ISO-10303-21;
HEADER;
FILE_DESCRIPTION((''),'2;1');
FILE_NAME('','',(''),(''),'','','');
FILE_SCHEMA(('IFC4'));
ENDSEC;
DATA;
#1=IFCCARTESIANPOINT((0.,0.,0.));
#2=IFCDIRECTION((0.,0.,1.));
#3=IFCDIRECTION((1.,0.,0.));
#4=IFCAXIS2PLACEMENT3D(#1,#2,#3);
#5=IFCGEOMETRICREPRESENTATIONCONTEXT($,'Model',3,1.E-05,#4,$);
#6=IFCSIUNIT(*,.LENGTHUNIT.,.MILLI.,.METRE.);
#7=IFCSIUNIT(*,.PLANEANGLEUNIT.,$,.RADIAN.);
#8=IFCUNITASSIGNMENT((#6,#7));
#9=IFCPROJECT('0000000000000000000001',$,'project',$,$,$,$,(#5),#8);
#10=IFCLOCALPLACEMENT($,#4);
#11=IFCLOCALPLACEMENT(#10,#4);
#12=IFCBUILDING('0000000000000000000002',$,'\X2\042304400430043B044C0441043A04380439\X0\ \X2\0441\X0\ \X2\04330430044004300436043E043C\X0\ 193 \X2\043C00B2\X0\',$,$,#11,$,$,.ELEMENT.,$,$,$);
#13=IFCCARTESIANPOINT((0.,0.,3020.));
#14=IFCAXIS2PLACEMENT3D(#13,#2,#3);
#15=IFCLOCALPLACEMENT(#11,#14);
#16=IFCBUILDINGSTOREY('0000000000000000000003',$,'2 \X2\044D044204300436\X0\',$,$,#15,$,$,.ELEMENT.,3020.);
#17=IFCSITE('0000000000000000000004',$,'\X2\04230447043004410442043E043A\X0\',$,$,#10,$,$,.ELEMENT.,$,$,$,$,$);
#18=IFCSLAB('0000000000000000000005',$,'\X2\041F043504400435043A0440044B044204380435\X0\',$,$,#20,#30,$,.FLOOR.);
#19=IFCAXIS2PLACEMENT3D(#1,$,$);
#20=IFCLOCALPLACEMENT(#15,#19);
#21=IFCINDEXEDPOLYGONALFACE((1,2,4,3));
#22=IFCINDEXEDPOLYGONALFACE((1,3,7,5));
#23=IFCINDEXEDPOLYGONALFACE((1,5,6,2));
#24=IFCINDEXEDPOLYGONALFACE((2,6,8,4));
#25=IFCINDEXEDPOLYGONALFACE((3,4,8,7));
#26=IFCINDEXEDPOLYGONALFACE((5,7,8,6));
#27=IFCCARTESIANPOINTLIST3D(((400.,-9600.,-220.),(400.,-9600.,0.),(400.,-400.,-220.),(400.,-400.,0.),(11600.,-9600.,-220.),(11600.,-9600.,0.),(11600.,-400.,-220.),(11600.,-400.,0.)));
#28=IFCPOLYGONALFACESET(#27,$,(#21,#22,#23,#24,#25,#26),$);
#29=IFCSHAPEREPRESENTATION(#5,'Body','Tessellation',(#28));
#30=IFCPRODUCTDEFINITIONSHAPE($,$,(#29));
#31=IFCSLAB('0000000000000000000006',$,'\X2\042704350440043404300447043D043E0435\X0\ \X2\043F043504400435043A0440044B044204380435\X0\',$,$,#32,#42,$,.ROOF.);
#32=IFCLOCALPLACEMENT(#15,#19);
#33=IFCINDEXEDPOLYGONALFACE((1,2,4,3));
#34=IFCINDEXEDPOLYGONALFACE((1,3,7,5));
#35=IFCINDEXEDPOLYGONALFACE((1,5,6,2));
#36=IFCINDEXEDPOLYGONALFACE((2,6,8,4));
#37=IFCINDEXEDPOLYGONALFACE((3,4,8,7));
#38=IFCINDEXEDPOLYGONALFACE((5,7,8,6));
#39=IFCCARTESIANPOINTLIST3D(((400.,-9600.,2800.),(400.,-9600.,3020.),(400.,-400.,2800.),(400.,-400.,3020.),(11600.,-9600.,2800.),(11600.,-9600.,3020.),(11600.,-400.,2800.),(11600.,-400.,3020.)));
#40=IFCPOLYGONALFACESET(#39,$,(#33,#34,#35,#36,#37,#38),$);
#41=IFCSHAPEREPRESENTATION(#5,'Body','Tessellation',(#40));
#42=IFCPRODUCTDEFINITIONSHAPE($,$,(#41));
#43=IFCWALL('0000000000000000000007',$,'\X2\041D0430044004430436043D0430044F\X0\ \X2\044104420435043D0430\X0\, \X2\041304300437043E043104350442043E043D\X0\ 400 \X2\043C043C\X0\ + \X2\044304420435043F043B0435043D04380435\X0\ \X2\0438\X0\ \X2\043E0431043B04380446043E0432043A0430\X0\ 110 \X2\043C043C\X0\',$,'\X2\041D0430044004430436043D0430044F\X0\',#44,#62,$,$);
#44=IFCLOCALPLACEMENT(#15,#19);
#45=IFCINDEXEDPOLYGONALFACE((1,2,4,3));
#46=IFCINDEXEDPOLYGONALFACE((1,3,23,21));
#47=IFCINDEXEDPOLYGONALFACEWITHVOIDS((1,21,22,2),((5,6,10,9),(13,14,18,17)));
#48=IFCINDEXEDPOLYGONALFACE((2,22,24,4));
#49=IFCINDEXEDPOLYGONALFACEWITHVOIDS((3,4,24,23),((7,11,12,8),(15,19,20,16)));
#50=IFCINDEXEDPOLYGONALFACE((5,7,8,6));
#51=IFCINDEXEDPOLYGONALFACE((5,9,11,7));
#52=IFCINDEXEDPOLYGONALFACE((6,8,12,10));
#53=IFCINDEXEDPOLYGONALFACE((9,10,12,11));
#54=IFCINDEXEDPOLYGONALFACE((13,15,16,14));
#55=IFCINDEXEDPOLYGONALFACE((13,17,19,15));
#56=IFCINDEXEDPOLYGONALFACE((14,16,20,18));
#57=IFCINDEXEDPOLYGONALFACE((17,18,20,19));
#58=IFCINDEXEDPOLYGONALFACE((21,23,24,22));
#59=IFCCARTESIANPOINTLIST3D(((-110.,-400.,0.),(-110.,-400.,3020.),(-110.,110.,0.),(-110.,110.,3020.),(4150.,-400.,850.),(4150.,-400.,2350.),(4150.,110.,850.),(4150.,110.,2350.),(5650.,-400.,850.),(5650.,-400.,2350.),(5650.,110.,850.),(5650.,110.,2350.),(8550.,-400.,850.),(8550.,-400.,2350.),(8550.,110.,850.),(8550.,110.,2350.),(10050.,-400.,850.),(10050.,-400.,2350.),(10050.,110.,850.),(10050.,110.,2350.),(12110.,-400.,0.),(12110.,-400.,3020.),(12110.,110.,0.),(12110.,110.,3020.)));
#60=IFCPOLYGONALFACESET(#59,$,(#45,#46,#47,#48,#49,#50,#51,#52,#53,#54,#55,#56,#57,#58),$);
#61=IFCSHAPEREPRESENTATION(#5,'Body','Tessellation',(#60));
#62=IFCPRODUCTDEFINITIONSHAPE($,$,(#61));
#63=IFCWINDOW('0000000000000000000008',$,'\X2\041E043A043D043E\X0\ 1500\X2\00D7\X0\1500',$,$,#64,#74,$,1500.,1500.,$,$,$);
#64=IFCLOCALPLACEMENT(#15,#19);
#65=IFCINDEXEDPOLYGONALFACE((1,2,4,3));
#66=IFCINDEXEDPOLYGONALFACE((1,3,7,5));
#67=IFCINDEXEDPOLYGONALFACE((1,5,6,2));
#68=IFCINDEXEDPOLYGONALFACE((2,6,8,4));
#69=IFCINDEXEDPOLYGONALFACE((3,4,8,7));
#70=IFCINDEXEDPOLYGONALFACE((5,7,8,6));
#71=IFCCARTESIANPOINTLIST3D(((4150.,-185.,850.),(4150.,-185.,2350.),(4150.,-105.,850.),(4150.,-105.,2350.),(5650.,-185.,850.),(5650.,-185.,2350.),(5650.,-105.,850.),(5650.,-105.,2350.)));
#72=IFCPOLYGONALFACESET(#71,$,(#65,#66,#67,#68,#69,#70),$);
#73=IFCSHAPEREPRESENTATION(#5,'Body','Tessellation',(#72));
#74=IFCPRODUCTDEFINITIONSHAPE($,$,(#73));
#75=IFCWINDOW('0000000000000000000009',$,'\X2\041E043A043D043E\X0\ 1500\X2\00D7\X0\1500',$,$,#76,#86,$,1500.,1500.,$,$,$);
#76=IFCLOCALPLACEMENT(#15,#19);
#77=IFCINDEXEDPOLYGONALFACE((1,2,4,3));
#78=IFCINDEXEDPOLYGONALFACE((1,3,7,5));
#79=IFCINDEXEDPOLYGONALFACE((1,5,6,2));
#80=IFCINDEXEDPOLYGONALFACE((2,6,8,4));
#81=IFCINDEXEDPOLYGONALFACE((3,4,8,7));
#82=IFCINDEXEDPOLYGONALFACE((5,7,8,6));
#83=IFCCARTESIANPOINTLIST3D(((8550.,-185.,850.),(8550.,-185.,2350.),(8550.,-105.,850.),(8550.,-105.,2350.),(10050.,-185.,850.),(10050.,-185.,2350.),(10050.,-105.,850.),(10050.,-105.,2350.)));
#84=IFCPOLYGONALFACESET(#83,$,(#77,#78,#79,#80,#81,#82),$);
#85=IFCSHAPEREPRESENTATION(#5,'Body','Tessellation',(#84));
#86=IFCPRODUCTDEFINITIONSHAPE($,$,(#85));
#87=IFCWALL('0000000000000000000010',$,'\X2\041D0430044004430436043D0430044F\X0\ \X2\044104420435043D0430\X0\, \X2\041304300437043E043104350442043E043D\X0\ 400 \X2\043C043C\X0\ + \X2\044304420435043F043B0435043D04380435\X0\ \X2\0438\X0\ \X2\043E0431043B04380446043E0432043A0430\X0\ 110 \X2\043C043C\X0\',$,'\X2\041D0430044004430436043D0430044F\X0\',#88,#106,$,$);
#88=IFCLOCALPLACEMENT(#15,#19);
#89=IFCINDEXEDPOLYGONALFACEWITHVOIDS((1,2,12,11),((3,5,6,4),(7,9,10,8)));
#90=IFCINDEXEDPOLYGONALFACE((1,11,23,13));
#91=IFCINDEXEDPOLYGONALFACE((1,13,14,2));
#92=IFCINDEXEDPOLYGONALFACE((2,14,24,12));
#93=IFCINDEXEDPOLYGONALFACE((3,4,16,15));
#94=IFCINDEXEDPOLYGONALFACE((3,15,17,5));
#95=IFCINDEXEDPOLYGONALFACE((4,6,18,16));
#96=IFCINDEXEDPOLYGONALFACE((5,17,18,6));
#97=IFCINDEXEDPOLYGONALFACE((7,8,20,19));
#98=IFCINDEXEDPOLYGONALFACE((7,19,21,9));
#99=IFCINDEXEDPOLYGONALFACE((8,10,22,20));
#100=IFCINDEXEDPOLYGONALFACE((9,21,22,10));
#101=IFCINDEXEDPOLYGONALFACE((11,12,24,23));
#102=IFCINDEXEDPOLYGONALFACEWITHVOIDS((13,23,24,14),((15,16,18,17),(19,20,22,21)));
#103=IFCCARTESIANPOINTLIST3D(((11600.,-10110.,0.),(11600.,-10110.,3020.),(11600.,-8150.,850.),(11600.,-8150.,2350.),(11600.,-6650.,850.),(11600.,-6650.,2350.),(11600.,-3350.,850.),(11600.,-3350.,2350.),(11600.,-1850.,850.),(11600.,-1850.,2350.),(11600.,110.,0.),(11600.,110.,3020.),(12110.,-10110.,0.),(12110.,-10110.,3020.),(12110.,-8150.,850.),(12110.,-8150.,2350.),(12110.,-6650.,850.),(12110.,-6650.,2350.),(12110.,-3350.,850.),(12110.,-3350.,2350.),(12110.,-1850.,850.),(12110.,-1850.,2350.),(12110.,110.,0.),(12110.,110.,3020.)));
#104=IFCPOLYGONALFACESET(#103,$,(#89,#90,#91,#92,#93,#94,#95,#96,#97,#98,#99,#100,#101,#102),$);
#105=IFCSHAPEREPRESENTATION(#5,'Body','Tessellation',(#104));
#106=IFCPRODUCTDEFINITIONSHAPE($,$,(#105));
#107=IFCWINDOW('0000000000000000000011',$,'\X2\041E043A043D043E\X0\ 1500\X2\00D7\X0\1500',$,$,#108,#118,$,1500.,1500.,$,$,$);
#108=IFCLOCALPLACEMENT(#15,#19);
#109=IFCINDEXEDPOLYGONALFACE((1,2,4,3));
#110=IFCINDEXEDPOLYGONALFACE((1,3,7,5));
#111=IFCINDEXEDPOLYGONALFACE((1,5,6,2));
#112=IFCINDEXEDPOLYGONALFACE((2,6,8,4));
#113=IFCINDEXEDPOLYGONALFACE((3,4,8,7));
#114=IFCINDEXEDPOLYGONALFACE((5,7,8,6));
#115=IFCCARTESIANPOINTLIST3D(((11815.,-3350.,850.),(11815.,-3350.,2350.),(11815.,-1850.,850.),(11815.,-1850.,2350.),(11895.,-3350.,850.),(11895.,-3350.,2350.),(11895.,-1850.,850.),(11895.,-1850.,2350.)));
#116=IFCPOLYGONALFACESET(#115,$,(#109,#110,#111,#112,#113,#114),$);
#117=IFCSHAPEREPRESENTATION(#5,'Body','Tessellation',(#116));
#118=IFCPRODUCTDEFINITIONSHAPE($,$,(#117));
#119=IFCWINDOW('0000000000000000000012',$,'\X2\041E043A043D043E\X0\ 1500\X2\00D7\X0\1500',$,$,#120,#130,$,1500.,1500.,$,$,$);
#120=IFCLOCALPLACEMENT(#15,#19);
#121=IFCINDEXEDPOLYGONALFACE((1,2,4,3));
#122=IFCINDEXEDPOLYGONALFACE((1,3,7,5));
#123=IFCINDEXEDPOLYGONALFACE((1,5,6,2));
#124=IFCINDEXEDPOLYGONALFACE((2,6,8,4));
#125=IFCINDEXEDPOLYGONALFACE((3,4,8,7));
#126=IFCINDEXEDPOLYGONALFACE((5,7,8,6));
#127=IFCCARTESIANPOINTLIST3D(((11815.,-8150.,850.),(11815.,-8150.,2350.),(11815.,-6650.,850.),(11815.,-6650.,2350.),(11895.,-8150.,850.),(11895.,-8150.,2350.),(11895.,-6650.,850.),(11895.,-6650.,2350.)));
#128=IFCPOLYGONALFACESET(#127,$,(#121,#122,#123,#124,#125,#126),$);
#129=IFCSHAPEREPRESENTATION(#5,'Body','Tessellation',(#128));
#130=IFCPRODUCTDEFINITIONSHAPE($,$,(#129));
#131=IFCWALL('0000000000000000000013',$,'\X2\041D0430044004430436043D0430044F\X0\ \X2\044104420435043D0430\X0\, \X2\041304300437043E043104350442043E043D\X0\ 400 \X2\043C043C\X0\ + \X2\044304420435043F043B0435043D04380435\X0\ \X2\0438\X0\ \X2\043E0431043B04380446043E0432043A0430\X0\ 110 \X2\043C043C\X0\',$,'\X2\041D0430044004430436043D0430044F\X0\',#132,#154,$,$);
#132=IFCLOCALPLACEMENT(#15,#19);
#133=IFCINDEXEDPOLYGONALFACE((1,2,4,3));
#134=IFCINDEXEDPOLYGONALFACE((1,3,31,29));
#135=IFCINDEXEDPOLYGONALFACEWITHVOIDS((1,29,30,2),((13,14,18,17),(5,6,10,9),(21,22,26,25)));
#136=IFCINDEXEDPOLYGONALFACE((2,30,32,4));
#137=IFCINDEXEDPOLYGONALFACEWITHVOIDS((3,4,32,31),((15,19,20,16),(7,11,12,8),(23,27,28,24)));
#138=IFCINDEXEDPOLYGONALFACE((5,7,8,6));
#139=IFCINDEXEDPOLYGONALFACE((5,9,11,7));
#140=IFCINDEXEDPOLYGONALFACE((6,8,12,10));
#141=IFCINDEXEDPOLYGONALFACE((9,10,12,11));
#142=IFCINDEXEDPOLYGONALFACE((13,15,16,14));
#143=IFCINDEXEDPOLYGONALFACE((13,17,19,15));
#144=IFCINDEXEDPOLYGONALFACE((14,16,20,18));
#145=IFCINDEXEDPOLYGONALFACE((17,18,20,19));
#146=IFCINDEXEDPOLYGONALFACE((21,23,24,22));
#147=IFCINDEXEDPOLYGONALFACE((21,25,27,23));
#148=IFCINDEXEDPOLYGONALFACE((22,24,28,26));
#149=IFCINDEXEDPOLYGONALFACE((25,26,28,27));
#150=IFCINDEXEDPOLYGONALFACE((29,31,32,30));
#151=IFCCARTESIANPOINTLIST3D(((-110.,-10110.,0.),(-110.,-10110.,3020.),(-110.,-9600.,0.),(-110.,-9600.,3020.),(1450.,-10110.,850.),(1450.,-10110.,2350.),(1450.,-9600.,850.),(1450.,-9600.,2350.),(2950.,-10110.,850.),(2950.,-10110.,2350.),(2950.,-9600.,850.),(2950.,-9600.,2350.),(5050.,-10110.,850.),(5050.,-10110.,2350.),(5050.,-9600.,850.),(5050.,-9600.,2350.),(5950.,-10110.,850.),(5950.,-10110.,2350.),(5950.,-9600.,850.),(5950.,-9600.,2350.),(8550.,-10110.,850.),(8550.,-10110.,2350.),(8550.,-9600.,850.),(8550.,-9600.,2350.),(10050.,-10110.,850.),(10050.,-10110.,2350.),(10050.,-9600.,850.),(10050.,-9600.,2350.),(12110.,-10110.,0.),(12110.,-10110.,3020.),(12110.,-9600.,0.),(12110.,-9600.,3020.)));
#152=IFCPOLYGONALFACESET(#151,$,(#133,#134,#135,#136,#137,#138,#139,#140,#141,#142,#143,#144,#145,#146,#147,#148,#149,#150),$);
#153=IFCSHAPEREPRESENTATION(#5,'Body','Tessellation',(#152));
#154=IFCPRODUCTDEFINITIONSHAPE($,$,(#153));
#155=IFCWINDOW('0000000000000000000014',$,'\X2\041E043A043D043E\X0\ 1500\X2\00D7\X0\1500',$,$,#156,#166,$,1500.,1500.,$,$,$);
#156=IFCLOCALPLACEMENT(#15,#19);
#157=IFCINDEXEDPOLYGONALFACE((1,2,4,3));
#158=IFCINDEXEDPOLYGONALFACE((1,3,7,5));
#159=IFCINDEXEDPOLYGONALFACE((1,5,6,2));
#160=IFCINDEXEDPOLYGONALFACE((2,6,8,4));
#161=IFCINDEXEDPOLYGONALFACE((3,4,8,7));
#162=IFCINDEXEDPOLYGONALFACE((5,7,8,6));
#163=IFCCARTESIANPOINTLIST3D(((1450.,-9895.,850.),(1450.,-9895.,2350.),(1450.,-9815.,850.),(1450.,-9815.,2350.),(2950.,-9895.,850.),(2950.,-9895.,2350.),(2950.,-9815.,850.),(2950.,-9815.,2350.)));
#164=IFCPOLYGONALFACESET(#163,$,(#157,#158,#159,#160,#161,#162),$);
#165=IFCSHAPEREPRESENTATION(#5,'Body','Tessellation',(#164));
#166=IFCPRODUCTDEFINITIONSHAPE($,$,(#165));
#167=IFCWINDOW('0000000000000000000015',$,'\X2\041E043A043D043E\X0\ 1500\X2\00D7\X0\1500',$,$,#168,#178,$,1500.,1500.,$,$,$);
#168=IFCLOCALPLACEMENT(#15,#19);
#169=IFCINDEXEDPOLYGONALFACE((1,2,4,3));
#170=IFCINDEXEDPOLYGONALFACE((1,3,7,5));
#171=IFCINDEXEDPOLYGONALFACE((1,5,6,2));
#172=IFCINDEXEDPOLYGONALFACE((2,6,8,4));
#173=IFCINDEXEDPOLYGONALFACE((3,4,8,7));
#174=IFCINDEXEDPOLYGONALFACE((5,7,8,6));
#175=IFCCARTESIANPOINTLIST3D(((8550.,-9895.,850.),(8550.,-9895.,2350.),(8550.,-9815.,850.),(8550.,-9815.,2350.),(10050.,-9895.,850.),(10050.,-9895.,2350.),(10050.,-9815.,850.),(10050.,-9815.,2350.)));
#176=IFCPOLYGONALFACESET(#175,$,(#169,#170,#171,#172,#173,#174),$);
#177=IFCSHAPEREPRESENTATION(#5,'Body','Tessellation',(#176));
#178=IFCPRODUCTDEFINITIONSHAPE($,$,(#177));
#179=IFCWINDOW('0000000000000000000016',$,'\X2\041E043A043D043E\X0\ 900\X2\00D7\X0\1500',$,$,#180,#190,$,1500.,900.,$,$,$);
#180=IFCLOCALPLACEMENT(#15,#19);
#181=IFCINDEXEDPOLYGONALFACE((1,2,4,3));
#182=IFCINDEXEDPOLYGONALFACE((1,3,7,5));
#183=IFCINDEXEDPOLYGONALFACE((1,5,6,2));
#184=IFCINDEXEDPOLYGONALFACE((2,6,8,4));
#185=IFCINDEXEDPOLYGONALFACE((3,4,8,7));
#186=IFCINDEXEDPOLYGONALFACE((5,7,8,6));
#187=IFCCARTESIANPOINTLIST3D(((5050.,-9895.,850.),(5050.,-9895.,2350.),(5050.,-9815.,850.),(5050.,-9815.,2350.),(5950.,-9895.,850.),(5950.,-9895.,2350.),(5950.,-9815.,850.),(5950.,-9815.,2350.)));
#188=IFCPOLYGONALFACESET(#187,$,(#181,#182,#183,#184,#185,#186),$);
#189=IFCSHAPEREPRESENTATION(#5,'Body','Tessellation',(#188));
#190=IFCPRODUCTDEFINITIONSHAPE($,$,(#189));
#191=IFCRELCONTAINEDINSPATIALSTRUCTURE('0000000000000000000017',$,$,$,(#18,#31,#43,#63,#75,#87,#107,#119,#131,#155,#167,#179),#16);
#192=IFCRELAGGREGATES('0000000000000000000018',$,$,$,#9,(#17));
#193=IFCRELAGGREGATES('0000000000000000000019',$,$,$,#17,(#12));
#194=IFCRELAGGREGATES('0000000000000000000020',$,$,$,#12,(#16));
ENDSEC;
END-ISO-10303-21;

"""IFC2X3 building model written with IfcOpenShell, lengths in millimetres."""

from ifc_helpers import new_model, si_unit, frame, frame_2d, origin, origin_with_axes, place, context, project, spatial, polyline, rectangle, outline, extrude, element, fill, save


model = new_model("IFC2X3")

# Units and contexts
model_context = context("Model", 3, precision=1e-05, world=origin_with_axes())
ifc_project = project(units=[si_unit("LENGTHUNIT", "METRE", prefix="MILLI"), si_unit("PLANEANGLEUNIT", "RADIAN")], contexts=[model_context])

# Site, building, storey
site_placement = place(None, origin_with_axes())
site = spatial("IfcSite", under=ifc_project, at=site_placement, Name="Участок", CompositionType="ELEMENT")
building_placement = place(site_placement, origin_with_axes())
building = spatial("IfcBuilding", under=site, at=building_placement, Name="Уральский с гаражом 193 м²", CompositionType="ELEMENT")
storey_placement = place(building_placement, frame((0.0, 0.0, 3020.0), z_axis=(0.0, 0.0, 1.0), x_axis=(1.0, 0.0, 0.0)))
storey = spatial("IfcBuildingStorey", under=building, at=storey_placement, Name="2 этаж", CompositionType="ELEMENT", Elevation=3020.0)

# Slabs
slab_1_placement = place(storey_placement, origin_with_axes())
element("IfcSlab", 1, at=slab_1_placement, inside=storey, Name="Перекрытие", PredefinedType="FLOOR", context=model_context, shape_type="SweptSolid", body=[
    extrude(outline(polyline([(400.0, -400.0), (11600.0, -400.0), (11600.0, -9600.0), (400.0, -9600.0), (400.0, -400.0)])), frame((0.0, 0.0, -220.0)), (0.0, 0.0, 1.0), 220.0),
])
slab_2_placement = place(storey_placement, origin_with_axes())
element("IfcSlab", 2, at=slab_2_placement, inside=storey, Name="Чердачное перекрытие", PredefinedType="ROOF", context=model_context, shape_type="SweptSolid", body=[
    extrude(outline(polyline([(400.0, -400.0), (11600.0, -400.0), (11600.0, -9600.0), (400.0, -9600.0), (400.0, -400.0)])), frame((0.0, 0.0, 2800.0)), (0.0, 0.0, 1.0), 220.0),
])

# Walls, openings, windows
wall_1_placement = place(storey_placement, origin_with_axes())
wall_1 = element("IfcWall", 3, at=wall_1_placement, inside=storey, Name="Наружная стена, Газобетон 400 мм + утепление и облицовка 110 мм", ObjectType="Наружная", context=model_context, shape_type="SweptSolid", body=[
    extrude(rectangle(XDim=12220.0, YDim=510.0, at=frame_2d((6000.0, -145.0))), origin(), (0.0, 0.0, 1.0), 3020.0),
])
opening_1_placement = place(storey_placement, origin_with_axes())
opening_1 = element("IfcOpeningElement", 4, at=opening_1_placement, cuts=wall_1, ObjectType="Opening", context=model_context, shape_type="SweptSolid", body=[
    extrude(rectangle(XDim=1500.0, YDim=530.0, at=frame_2d((4900.0, -145.0))), frame((0.0, 0.0, 850.0)), (0.0, 0.0, 1.0), 1500.0),
])
opening_2_placement = place(storey_placement, origin_with_axes())
opening_2 = element("IfcOpeningElement", 5, at=opening_2_placement, cuts=wall_1, ObjectType="Opening", context=model_context, shape_type="SweptSolid", body=[
    extrude(rectangle(XDim=1500.0, YDim=530.0, at=frame_2d((9300.0, -145.0))), frame((0.0, 0.0, 850.0)), (0.0, 0.0, 1.0), 1500.0),
])
window_1_placement = place(storey_placement, origin_with_axes())
window_1 = element("IfcWindow", 6, at=window_1_placement, inside=storey, Name="Окно 1500×1500", OverallHeight=1500.0, OverallWidth=1500.0, context=model_context, shape_type="SweptSolid", body=[
    extrude(rectangle(XDim=1500.0, YDim=80.0, at=frame_2d((4900.0, -145.0))), frame((0.0, 0.0, 850.0)), (0.0, 0.0, 1.0), 1500.0),
])
fill(opening_1, window_1)
window_2_placement = place(storey_placement, origin_with_axes())
window_2 = element("IfcWindow", 7, at=window_2_placement, inside=storey, Name="Окно 1500×1500", OverallHeight=1500.0, OverallWidth=1500.0, context=model_context, shape_type="SweptSolid", body=[
    extrude(rectangle(XDim=1500.0, YDim=80.0, at=frame_2d((9300.0, -145.0))), frame((0.0, 0.0, 850.0)), (0.0, 0.0, 1.0), 1500.0),
])
fill(opening_2, window_2)
wall_2_placement = place(storey_placement, origin_with_axes())
wall_2 = element("IfcWall", 8, at=wall_2_placement, inside=storey, Name="Наружная стена, Газобетон 400 мм + утепление и облицовка 110 мм", ObjectType="Наружная", context=model_context, shape_type="SweptSolid", body=[
    extrude(rectangle(XDim=510.0, YDim=10220.0, at=frame_2d((11855.0, -5000.0))), origin(), (0.0, 0.0, 1.0), 3020.0),
])
opening_3_placement = place(storey_placement, origin_with_axes())
opening_3 = element("IfcOpeningElement", 9, at=opening_3_placement, cuts=wall_2, ObjectType="Opening", context=model_context, shape_type="SweptSolid", body=[
    extrude(rectangle(XDim=530.0, YDim=1500.0, at=frame_2d((11855.0, -2600.0))), frame((0.0, 0.0, 850.0)), (0.0, 0.0, 1.0), 1500.0),
])
opening_4_placement = place(storey_placement, origin_with_axes())
opening_4 = element("IfcOpeningElement", 10, at=opening_4_placement, cuts=wall_2, ObjectType="Opening", context=model_context, shape_type="SweptSolid", body=[
    extrude(rectangle(XDim=530.0, YDim=1500.0, at=frame_2d((11855.0, -7400.0))), frame((0.0, 0.0, 850.0)), (0.0, 0.0, 1.0), 1500.0),
])
window_3_placement = place(storey_placement, origin_with_axes())
window_3 = element("IfcWindow", 11, at=window_3_placement, inside=storey, Name="Окно 1500×1500", OverallHeight=1500.0, OverallWidth=1500.0, context=model_context, shape_type="SweptSolid", body=[
    extrude(rectangle(XDim=80.0, YDim=1500.0, at=frame_2d((11855.0, -2600.0))), frame((0.0, 0.0, 850.0)), (0.0, 0.0, 1.0), 1500.0),
])
fill(opening_3, window_3)
window_4_placement = place(storey_placement, origin_with_axes())
window_4 = element("IfcWindow", 12, at=window_4_placement, inside=storey, Name="Окно 1500×1500", OverallHeight=1500.0, OverallWidth=1500.0, context=model_context, shape_type="SweptSolid", body=[
    extrude(rectangle(XDim=80.0, YDim=1500.0, at=frame_2d((11855.0, -7400.0))), frame((0.0, 0.0, 850.0)), (0.0, 0.0, 1.0), 1500.0),
])
fill(opening_4, window_4)
wall_3_placement = place(storey_placement, origin_with_axes())
wall_3 = element("IfcWall", 13, at=wall_3_placement, inside=storey, Name="Наружная стена, Газобетон 400 мм + утепление и облицовка 110 мм", ObjectType="Наружная", context=model_context, shape_type="SweptSolid", body=[
    extrude(rectangle(XDim=12220.0, YDim=510.0, at=frame_2d((6000.0, -9855.0))), origin(), (0.0, 0.0, 1.0), 3020.0),
])
opening_5_placement = place(storey_placement, origin_with_axes())
opening_5 = element("IfcOpeningElement", 14, at=opening_5_placement, cuts=wall_3, ObjectType="Opening", context=model_context, shape_type="SweptSolid", body=[
    extrude(rectangle(XDim=1500.0, YDim=530.0, at=frame_2d((2200.0, -9855.0))), frame((0.0, 0.0, 850.0)), (0.0, 0.0, 1.0), 1500.0),
])
opening_6_placement = place(storey_placement, origin_with_axes())
opening_6 = element("IfcOpeningElement", 15, at=opening_6_placement, cuts=wall_3, ObjectType="Opening", context=model_context, shape_type="SweptSolid", body=[
    extrude(rectangle(XDim=1500.0, YDim=530.0, at=frame_2d((9300.0, -9855.0))), frame((0.0, 0.0, 850.0)), (0.0, 0.0, 1.0), 1500.0),
])
opening_7_placement = place(storey_placement, origin_with_axes())
opening_7 = element("IfcOpeningElement", 16, at=opening_7_placement, cuts=wall_3, ObjectType="Opening", context=model_context, shape_type="SweptSolid", body=[
    extrude(rectangle(XDim=900.0, YDim=530.0, at=frame_2d((5500.0, -9855.0))), frame((0.0, 0.0, 850.0)), (0.0, 0.0, 1.0), 1500.0),
])
window_5_placement = place(storey_placement, origin_with_axes())
window_5 = element("IfcWindow", 17, at=window_5_placement, inside=storey, Name="Окно 1500×1500", OverallHeight=1500.0, OverallWidth=1500.0, context=model_context, shape_type="SweptSolid", body=[
    extrude(rectangle(XDim=1500.0, YDim=80.0, at=frame_2d((2200.0, -9855.0))), frame((0.0, 0.0, 850.0)), (0.0, 0.0, 1.0), 1500.0),
])
fill(opening_5, window_5)
window_6_placement = place(storey_placement, origin_with_axes())
window_6 = element("IfcWindow", 18, at=window_6_placement, inside=storey, Name="Окно 1500×1500", OverallHeight=1500.0, OverallWidth=1500.0, context=model_context, shape_type="SweptSolid", body=[
    extrude(rectangle(XDim=1500.0, YDim=80.0, at=frame_2d((9300.0, -9855.0))), frame((0.0, 0.0, 850.0)), (0.0, 0.0, 1.0), 1500.0),
])
fill(opening_6, window_6)
window_7_placement = place(storey_placement, origin_with_axes())
window_7 = element("IfcWindow", 19, at=window_7_placement, inside=storey, Name="Окно 900×1500", OverallHeight=1500.0, OverallWidth=900.0, context=model_context, shape_type="SweptSolid", body=[
    extrude(rectangle(XDim=900.0, YDim=80.0, at=frame_2d((5500.0, -9855.0))), frame((0.0, 0.0, 850.0)), (0.0, 0.0, 1.0), 1500.0),
])
fill(opening_7, window_7)

save(model, "model.ifc")
